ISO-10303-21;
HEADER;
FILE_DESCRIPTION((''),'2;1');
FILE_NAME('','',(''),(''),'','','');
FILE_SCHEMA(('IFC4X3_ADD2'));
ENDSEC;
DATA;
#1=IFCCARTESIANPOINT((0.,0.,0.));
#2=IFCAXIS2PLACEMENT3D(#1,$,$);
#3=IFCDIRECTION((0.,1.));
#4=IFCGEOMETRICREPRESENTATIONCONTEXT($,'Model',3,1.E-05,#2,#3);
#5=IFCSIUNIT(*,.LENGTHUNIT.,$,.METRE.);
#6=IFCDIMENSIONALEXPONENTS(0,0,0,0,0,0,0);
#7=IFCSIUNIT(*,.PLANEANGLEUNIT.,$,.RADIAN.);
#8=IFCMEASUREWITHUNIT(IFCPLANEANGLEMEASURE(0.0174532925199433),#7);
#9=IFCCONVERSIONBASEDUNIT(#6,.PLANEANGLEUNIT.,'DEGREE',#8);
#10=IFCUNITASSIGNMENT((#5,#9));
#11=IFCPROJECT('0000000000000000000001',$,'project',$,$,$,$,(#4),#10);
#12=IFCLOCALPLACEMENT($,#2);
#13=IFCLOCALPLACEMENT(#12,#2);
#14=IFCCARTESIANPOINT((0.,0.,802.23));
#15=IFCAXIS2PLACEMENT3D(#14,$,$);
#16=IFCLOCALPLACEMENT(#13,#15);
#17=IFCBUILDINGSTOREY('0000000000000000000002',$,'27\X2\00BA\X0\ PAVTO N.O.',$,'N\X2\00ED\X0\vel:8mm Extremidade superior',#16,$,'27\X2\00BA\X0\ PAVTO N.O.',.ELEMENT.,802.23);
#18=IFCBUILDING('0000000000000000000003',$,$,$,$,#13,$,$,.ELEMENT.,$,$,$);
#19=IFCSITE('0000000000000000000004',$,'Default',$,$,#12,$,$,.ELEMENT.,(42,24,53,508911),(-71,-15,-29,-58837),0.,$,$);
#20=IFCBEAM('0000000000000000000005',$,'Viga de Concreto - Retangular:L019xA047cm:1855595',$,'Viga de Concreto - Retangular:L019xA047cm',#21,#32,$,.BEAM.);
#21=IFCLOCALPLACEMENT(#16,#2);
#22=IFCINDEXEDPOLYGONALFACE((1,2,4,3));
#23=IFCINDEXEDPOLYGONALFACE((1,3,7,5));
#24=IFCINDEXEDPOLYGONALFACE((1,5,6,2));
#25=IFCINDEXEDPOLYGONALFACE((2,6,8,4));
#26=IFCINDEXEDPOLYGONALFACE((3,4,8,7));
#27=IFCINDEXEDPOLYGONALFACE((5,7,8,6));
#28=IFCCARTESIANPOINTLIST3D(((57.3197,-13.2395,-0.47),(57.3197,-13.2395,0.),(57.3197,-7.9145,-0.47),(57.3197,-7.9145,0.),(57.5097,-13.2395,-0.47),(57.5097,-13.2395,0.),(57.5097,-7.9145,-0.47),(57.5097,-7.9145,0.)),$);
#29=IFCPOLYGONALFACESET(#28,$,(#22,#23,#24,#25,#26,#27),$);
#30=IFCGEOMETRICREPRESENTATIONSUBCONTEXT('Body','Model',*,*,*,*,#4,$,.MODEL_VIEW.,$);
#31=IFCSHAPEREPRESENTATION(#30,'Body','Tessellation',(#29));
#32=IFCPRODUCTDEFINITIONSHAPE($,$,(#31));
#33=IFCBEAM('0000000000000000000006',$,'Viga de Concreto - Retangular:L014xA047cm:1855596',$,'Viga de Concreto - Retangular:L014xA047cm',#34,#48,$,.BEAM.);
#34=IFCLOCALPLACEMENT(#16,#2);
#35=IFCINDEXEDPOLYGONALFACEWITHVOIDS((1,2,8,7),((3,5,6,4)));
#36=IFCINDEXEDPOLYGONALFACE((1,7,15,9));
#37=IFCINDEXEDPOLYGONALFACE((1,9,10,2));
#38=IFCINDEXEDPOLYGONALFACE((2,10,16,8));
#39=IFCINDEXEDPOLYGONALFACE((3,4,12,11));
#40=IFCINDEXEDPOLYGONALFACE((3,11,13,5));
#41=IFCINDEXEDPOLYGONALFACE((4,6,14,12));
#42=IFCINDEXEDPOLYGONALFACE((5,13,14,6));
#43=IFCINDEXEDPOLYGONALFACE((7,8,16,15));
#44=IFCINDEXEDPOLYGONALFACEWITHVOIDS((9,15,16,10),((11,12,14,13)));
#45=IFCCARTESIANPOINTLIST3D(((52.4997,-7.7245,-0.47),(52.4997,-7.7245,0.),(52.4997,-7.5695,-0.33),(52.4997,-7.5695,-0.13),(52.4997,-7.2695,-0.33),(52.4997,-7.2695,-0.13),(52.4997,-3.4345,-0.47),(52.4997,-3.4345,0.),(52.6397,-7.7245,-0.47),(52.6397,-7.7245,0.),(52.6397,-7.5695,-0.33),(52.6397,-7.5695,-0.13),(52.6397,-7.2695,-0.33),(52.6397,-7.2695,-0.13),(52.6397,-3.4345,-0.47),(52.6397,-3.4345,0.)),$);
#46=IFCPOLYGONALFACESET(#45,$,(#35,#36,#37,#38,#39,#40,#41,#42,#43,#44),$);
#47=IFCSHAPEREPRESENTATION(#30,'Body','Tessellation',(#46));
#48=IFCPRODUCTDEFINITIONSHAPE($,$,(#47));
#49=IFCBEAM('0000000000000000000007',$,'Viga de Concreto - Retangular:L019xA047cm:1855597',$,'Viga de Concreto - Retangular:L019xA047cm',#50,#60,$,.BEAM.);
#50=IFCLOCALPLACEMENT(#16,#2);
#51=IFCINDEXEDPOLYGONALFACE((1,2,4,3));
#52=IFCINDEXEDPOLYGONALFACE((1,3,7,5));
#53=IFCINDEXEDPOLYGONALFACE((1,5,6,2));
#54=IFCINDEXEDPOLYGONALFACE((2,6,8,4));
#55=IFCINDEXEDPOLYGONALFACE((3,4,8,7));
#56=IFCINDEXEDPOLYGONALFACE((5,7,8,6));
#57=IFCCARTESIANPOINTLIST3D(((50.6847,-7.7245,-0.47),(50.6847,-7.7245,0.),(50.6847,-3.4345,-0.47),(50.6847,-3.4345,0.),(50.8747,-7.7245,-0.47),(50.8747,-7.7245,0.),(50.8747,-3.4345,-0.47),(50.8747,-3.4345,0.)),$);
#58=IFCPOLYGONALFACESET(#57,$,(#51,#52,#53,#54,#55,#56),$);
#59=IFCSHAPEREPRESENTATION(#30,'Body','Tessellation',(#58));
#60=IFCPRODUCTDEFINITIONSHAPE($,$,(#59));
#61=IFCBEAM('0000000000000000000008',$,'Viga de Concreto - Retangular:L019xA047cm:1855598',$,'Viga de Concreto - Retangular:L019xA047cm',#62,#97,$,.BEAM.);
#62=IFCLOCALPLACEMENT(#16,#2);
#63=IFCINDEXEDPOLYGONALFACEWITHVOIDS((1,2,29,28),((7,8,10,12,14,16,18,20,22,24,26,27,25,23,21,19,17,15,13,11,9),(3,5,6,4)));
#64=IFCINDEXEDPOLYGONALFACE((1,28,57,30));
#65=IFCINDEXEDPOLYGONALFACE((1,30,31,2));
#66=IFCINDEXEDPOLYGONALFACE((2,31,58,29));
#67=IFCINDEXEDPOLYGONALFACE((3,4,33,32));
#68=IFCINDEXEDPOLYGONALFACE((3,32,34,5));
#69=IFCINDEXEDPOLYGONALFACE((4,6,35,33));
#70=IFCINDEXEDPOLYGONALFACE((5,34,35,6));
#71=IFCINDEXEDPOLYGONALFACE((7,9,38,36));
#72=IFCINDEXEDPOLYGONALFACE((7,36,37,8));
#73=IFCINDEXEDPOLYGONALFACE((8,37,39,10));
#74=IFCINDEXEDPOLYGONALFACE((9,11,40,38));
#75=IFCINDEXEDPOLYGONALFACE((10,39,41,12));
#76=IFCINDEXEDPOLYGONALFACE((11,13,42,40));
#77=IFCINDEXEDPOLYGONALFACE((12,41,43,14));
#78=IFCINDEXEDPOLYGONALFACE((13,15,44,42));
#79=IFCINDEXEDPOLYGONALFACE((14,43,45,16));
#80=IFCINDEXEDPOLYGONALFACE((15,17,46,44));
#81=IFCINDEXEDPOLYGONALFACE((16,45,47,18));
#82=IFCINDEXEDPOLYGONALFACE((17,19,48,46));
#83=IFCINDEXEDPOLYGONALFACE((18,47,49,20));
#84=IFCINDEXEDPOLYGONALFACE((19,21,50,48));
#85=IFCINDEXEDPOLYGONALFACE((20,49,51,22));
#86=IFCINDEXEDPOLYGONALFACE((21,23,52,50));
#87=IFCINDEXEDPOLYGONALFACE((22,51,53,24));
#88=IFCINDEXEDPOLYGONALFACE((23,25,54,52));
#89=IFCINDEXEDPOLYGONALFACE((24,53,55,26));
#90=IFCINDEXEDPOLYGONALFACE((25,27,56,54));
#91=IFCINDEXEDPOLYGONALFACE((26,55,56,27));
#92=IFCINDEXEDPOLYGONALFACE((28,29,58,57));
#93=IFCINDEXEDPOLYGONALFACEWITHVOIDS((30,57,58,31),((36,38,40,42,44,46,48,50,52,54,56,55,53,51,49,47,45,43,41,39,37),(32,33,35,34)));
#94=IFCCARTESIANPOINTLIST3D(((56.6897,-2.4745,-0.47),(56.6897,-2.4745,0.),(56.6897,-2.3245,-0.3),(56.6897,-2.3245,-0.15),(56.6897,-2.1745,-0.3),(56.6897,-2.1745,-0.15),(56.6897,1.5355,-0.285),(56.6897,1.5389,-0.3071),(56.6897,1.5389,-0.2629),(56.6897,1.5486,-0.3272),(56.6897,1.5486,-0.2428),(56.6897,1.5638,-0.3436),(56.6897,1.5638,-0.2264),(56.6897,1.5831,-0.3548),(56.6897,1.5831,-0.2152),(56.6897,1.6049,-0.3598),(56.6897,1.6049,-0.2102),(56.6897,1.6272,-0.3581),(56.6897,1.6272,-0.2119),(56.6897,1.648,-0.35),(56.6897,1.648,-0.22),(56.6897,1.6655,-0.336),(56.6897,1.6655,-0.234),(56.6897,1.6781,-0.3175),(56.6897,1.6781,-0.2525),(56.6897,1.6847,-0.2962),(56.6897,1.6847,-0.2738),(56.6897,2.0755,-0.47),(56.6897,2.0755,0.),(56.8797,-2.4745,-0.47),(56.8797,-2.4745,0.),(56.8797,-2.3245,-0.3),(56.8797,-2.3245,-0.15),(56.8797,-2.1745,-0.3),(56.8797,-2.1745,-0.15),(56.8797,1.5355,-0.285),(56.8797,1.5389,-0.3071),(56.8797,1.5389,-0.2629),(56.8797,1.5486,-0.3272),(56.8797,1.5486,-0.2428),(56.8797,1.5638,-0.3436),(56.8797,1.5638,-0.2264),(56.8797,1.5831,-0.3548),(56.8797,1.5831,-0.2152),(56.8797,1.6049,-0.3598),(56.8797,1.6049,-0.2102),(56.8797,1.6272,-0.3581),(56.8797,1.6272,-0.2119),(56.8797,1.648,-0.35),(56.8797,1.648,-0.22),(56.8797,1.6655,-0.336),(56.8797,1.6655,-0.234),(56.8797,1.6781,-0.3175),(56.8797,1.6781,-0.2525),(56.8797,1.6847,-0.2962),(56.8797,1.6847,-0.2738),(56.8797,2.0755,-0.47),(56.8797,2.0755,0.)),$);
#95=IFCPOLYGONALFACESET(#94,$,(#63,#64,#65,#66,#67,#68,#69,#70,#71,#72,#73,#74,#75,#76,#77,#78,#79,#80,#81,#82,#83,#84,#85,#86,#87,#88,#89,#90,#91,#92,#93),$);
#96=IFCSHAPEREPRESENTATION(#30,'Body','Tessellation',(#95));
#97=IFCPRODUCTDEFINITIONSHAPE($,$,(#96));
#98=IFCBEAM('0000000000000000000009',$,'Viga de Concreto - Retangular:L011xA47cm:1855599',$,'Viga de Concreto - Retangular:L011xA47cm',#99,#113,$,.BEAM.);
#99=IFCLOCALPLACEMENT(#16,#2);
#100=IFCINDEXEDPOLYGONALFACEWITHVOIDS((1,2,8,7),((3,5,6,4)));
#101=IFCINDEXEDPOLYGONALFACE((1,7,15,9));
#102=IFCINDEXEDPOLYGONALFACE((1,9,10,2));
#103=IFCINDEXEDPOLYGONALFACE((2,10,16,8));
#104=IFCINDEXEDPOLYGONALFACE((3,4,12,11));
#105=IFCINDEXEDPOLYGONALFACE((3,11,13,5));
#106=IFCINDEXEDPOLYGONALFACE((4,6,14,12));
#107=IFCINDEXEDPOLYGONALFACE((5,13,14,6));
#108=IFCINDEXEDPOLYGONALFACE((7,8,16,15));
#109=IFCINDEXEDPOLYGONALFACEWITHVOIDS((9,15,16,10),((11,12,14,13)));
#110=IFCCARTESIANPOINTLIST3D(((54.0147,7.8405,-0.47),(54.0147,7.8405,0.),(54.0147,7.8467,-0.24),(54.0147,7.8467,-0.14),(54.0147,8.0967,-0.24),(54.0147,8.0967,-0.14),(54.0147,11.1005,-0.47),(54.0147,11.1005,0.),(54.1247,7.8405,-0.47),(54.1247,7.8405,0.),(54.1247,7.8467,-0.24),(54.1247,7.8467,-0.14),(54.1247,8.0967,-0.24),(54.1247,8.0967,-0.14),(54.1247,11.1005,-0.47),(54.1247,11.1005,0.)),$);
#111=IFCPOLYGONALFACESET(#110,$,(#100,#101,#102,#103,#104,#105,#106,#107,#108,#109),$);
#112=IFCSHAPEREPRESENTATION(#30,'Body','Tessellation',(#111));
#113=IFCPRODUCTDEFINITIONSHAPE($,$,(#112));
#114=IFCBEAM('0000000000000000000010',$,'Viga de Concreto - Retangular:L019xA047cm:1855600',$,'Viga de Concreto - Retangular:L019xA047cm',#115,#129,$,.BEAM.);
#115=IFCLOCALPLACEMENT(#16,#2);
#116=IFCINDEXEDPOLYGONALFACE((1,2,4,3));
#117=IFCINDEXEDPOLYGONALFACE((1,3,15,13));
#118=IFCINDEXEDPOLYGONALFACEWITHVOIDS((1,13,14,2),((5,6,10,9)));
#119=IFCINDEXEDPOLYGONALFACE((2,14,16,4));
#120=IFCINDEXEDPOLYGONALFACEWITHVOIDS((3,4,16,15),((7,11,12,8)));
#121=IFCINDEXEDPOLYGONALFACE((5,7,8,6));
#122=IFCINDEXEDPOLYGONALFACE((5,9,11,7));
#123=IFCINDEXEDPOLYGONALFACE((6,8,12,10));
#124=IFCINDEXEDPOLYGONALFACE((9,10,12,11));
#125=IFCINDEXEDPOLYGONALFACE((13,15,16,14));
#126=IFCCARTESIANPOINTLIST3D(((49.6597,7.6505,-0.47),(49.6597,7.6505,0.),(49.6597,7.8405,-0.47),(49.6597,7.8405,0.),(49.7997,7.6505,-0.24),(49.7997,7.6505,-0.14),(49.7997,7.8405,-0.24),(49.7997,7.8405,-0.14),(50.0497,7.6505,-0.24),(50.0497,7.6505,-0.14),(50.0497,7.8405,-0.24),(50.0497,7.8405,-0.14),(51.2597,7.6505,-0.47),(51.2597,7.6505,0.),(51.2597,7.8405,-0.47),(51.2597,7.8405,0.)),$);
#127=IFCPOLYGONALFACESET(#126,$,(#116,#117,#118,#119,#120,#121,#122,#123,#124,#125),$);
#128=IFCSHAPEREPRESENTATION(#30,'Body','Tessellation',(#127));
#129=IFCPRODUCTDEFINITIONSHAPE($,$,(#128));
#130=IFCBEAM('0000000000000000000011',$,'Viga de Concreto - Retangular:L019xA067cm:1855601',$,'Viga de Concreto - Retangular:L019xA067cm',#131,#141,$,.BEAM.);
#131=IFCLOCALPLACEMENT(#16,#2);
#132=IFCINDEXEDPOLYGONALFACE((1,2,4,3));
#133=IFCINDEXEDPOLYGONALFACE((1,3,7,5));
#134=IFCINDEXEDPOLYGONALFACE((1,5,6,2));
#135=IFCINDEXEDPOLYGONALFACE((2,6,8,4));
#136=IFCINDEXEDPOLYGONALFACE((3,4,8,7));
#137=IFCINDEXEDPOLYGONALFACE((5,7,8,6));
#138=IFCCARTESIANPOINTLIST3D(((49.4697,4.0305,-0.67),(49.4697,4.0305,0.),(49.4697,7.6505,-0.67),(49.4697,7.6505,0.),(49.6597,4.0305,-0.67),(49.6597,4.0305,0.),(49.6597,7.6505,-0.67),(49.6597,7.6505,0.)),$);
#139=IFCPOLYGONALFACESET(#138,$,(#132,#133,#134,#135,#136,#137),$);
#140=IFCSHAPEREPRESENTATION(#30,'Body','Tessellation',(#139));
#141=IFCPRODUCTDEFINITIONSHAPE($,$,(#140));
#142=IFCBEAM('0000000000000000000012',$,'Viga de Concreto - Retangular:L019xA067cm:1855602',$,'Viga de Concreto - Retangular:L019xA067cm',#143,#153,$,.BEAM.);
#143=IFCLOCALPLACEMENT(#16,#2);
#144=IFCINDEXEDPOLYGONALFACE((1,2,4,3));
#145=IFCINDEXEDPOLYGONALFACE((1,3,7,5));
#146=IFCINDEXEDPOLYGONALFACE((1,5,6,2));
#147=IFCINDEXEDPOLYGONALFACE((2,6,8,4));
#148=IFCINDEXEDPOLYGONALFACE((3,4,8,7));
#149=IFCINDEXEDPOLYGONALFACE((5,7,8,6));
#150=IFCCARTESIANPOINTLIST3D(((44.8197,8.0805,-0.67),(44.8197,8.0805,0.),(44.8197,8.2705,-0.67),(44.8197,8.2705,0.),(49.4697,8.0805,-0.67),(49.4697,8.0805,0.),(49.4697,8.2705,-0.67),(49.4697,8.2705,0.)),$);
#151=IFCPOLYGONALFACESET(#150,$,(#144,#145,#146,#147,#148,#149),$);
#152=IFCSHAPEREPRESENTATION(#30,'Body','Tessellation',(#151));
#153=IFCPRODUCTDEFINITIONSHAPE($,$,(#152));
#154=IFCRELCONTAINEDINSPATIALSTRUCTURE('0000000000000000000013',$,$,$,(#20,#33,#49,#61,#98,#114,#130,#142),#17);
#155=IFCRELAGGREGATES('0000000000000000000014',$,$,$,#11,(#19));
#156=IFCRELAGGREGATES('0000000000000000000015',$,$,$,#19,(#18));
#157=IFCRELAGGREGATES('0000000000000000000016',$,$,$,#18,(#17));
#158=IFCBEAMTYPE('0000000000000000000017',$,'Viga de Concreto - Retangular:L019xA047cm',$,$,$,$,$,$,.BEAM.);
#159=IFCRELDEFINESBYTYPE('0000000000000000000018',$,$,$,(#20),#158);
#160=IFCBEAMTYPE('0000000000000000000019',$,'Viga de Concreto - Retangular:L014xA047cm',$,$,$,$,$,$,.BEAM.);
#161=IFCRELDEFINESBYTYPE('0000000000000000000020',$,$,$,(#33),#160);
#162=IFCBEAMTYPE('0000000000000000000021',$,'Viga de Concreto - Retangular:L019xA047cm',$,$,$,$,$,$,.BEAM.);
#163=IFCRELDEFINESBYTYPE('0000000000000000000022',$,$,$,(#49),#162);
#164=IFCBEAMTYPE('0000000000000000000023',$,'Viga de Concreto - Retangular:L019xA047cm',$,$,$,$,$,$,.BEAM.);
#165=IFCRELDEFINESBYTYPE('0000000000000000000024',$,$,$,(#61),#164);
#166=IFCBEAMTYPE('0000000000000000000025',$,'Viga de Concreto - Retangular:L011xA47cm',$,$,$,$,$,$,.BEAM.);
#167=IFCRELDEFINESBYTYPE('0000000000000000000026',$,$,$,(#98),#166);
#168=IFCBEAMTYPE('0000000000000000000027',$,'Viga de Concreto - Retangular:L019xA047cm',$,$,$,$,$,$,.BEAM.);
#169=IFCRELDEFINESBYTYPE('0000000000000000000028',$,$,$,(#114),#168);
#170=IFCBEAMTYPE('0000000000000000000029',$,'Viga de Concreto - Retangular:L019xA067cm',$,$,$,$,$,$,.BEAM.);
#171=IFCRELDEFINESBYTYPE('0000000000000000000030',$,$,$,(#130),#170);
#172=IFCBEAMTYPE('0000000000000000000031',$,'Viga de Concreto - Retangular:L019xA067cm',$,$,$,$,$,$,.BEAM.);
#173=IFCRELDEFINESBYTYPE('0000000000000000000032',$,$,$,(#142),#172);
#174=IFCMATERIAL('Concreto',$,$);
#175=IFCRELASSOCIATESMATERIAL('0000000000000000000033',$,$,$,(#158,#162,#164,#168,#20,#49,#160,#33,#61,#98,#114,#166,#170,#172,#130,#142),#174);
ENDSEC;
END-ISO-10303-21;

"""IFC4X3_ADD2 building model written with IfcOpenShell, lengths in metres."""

from ifc_helpers import new_model, entity, si_unit, converted_unit, direction, frame, frame_2d, origin, origin_2d_with_axis, place, context, subcontext, project, spatial, polyline, segment, composite_curve, rectangle, circle, outline, extrude, boolean, source, transform, mapped, material, material_profile, profile_set, profile_usage, type_object, type_shapes, element, save


model = new_model("IFC4X3_ADD2")

# Units and contexts
model_context = context("Model", 3, precision=1e-05, world=origin(), true_north=direction((0.0, 1.0)))
body_context = subcontext(model_context, "Body", "Model", "MODEL_VIEW")
ifc_project = project(units=[si_unit("LENGTHUNIT", "METRE"), converted_unit("PLANEANGLEUNIT", "DEGREE", entity("IfcPlaneAngleMeasure", 0.0174532925199433), si_unit("PLANEANGLEUNIT", "RADIAN"), dimensions=[0, 0, 0, 0, 0, 0, 0])], contexts=[model_context])

# Site, building, storey
site_placement = place(None, origin())
site = spatial("IfcSite", under=ifc_project, at=site_placement, Name="Default", CompositionType="ELEMENT", RefLatitude=(42, 24, 53, 508911), RefLongitude=(-71, -15, -29, -58837), RefElevation=0.0)
building_placement = place(site_placement, origin())
building = spatial("IfcBuilding", under=site, at=building_placement, CompositionType="ELEMENT")
storey_placement = place(building_placement, frame((0.0, 0.0, 802.23)))
storey = spatial("IfcBuildingStorey", under=building, at=storey_placement, Name="27º PAVTO N.O.", ObjectType="Nível:8mm Extremidade superior", LongName="27º PAVTO N.O.", CompositionType="ELEMENT", Elevation=802.23)

# Beams
ifc_material = material(Name="Concreto")
ifc_material_profile_1 = material_profile(ifc_material, rectangle(XDim=0.47, YDim=0.14, at=frame_2d((0.0, 0.0), x_axis=(0.0, 1.0))), Name="L014xA047cm")
ifc_profile_set_1 = profile_set([ifc_material_profile_1], Name="L014xA047cm")
ifc_material_profile_2 = material_profile(ifc_material, rectangle(XDim=0.47, YDim=0.19, at=frame_2d((0.0, 0.0), x_axis=(0.0, 1.0))), Name="L019xA047cm")
ifc_profile_set_2 = profile_set([ifc_material_profile_2], Name="L019xA047cm")
ifc_profile_usage_1 = profile_usage(ifc_profile_set_2, cardinal=8)
ifc_material_profile_3 = material_profile(ifc_material, outline(composite_curve([segment(polyline([(-0.055, 0.235, 0.0), (0.055, 0.235, 0.0)]), True, "CONTINUOUS"), segment(polyline([(0.055, 0.235, 0.0), (0.055, -0.235, 0.0)]), True, "CONTINUOUS"), segment(polyline([(0.055, -0.235, 0.0), (-0.055, -0.235, 0.0)]), True, "CONTINUOUS"), segment(polyline([(-0.055, -0.235, 0.0), (-0.055, 0.235, 0.0)]), True, "CONTINUOUS")], self_intersect=False), kind="CURVE"), Name="L011xA47cm")
ifc_material_profile_4 = material_profile(ifc_material, outline(composite_curve([segment(polyline([(1.6775, -0.055, -0.235), (1.6775, -0.055, 0.235)]), True, "CONTINUOUS"), segment(polyline([(1.6775, -0.055, 0.235), (-1.6775, -0.055, 0.235)]), True, "CONTINUOUS"), segment(polyline([(-1.6775, -0.055, 0.235), (-1.6775, -0.055, -0.235)]), True, "CONTINUOUS"), segment(polyline([(-1.6775, -0.055, -0.235), (1.6775, -0.055, -0.235)]), True, "CONTINUOUS")], self_intersect=False), kind="CURVE"), Name="L011xA47cm")
ifc_profile_set_3 = profile_set([ifc_material_profile_3, ifc_material_profile_4], Name="L011xA47cm")
beam_type_1 = type_object("IfcBeamType", Name="Viga de Concreto - Retangular:L019xA047cm", PredefinedType="BEAM", material=ifc_profile_set_2)
shared_shape_1 = source(origin(), body_context, "Body", "SweptSolid", [
    extrude(rectangle(XDim=0.47, YDim=0.19, at=frame_2d((0.0, 0.0), x_axis=(0.0, 1.0))), frame((57.4147, -13.2395, 801.995), z_axis=(0.0, 1.0, 0.0), x_axis=(-1.0, 0.0, 0.0)), (0.0, 0.0, 1.0), 5.325),
])
type_shapes(beam_type_1, [shared_shape_1])
beam_1_placement = place(storey_placement, frame((0.0, 0.0, -802.23)))
element("IfcBeam", 1, at=beam_1_placement, inside=storey, type_object=beam_type_1, material=ifc_profile_usage_1, Name="Viga de Concreto - Retangular:L019xA047cm:1855595", ObjectType="Viga de Concreto - Retangular:L019xA047cm", PredefinedType="BEAM", context=body_context, shape_type="MappedRepresentation", body=[
    mapped(shared_shape_1, transform((0.0, 0.0, 0.0), scale=1.0)),
])
beam_type_2 = type_object("IfcBeamType", Name="Viga de Concreto - Retangular:L014xA047cm", PredefinedType="BEAM", material=ifc_profile_set_1)
shared_shape_2 = source(origin(), body_context, "Body", "CSG", [
    boolean("DIFFERENCE", extrude(rectangle(XDim=0.47, YDim=0.14, at=frame_2d((0.0, 0.0), x_axis=(0.0, 1.0))), frame((52.5697, -7.7245, 801.995), z_axis=(0.0, 1.0, 0.0), x_axis=(-1.0, 0.0, 0.0)), (0.0, 0.0, 1.0), 4.29), extrude(rectangle(XDim=0.2, YDim=0.3, at=frame_2d((0.0, 0.0), x_axis=(0.0, 1.0))), frame((52.6397, -7.4195, 802.0), z_axis=(-1.0, 0.0, 0.0), x_axis=(0.0, 1.0, 0.0)), (0.0, 0.0, 1.0), 0.14)),
])
type_shapes(beam_type_2, [shared_shape_2])
beam_2_placement = place(storey_placement, frame((0.0, 0.0, -802.23)))
element("IfcBeam", 2, at=beam_2_placement, inside=storey, type_object=beam_type_2, material=ifc_material, Name="Viga de Concreto - Retangular:L014xA047cm:1855596", ObjectType="Viga de Concreto - Retangular:L014xA047cm", PredefinedType="BEAM", context=body_context, shape_type="MappedRepresentation", body=[
    mapped(shared_shape_2, transform((0.0, 0.0, 0.0), scale=1.0)),
])
beam_type_3 = type_object("IfcBeamType", Name="Viga de Concreto - Retangular:L019xA047cm", PredefinedType="BEAM", material=ifc_profile_set_2)
shared_shape_3 = source(origin(), body_context, "Body", "SweptSolid", [
    extrude(rectangle(XDim=0.47, YDim=0.19, at=frame_2d((0.0, 0.0), x_axis=(0.0, 1.0))), frame((50.7797, -7.7245, 801.995), z_axis=(0.0, 1.0, 0.0), x_axis=(-1.0, 0.0, 0.0)), (0.0, 0.0, 1.0), 4.29),
])
type_shapes(beam_type_3, [shared_shape_3])
beam_3_placement = place(storey_placement, frame((0.0, 0.0, -802.23)))
element("IfcBeam", 3, at=beam_3_placement, inside=storey, type_object=beam_type_3, material=ifc_profile_usage_1, Name="Viga de Concreto - Retangular:L019xA047cm:1855597", ObjectType="Viga de Concreto - Retangular:L019xA047cm", PredefinedType="BEAM", context=body_context, shape_type="MappedRepresentation", body=[
    mapped(shared_shape_3, transform((0.0, 0.0, 0.0), scale=1.0)),
])
beam_type_4 = type_object("IfcBeamType", Name="Viga de Concreto - Retangular:L019xA047cm", PredefinedType="BEAM", material=ifc_profile_set_2)
shared_shape_4 = source(origin(), body_context, "Body", "CSG", [
    boolean("DIFFERENCE", boolean("DIFFERENCE", extrude(rectangle(XDim=0.47, YDim=0.19, at=frame_2d((0.0, 0.0), x_axis=(0.0, 1.0))), frame((56.7847, 2.0755, 801.995), z_axis=(0.0, -1.0, 0.0), x_axis=(-1.0, 0.0, 0.0)), (0.0, 0.0, 1.0), 4.55), extrude(circle(Radius=0.075, at=origin_2d_with_axis()), frame((56.6897, 1.6105, 801.945), z_axis=(1.0, 0.0, 0.0), x_axis=(0.0, -1.0, 0.0)), (0.0, 0.0, 1.0), 0.19)), extrude(rectangle(XDim=0.15, YDim=0.15, at=frame_2d((0.0, 0.0), x_axis=(0.0, 1.0))), frame((56.8797, -2.2495, 802.005), z_axis=(-1.0, 0.0, 0.0), x_axis=(0.0, 1.0, 0.0)), (0.0, 0.0, 1.0), 0.19)),
])
type_shapes(beam_type_4, [shared_shape_4])
beam_4_placement = place(storey_placement, frame((0.0, 0.0, -802.23)))
element("IfcBeam", 4, at=beam_4_placement, inside=storey, type_object=beam_type_4, material=ifc_material, Name="Viga de Concreto - Retangular:L019xA047cm:1855598", ObjectType="Viga de Concreto - Retangular:L019xA047cm", PredefinedType="BEAM", context=body_context, shape_type="MappedRepresentation", body=[
    mapped(shared_shape_4, transform((0.0, 0.0, 0.0), scale=1.0)),
])
beam_type_5 = type_object("IfcBeamType", Name="Viga de Concreto - Retangular:L011xA47cm", PredefinedType="BEAM", material=ifc_profile_set_3)
shared_shape_5 = source(origin(), body_context, "Body", "CSG", [
    boolean("DIFFERENCE", extrude(rectangle(XDim=0.47, YDim=0.11, at=frame_2d((0.0, 0.0), x_axis=(0.0, 1.0))), frame((54.0697, 7.8405, 801.995), z_axis=(0.0, 1.0, 0.0), x_axis=(-1.0, 0.0, 0.0)), (0.0, 0.0, 1.0), 3.26), extrude(rectangle(XDim=0.1, YDim=0.25, at=frame_2d((0.0, 0.0), x_axis=(0.0, 1.0))), frame((54.1247, 7.9717, 802.04), z_axis=(-1.0, 0.0, 0.0), x_axis=(0.0, 1.0, 0.0)), (0.0, 0.0, 1.0), 0.11)),
])
type_shapes(beam_type_5, [shared_shape_5])
beam_5_placement = place(storey_placement, frame((0.0, 0.0, -802.23)))
element("IfcBeam", 5, at=beam_5_placement, inside=storey, type_object=beam_type_5, material=ifc_material, Name="Viga de Concreto - Retangular:L011xA47cm:1855599", ObjectType="Viga de Concreto - Retangular:L011xA47cm", PredefinedType="BEAM", context=body_context, shape_type="MappedRepresentation", body=[
    mapped(shared_shape_5, transform((0.0, 0.0, 0.0), scale=1.0)),
])
beam_type_6 = type_object("IfcBeamType", Name="Viga de Concreto - Retangular:L019xA047cm", PredefinedType="BEAM", material=ifc_profile_set_2)
shared_shape_6 = source(origin(), body_context, "Body", "CSG", [
    boolean("DIFFERENCE", extrude(rectangle(XDim=0.47, YDim=0.19, at=frame_2d((0.0, 0.0), x_axis=(0.0, 1.0))), frame((49.6597, 7.7455, 801.995), z_axis=(1.0, 0.0, 0.0), x_axis=(0.0, 1.0, 0.0)), (0.0, 0.0, 1.0), 1.6), extrude(rectangle(XDim=0.1, YDim=0.25, at=frame_2d((0.0, 0.0), x_axis=(0.0, 1.0))), frame((49.9247, 7.8405, 802.04), z_axis=(0.0, -1.0, 0.0), x_axis=(-1.0, 0.0, 0.0)), (0.0, 0.0, 1.0), 0.19)),
])
type_shapes(beam_type_6, [shared_shape_6])
beam_6_placement = place(storey_placement, frame((0.0, 0.0, -802.23)))
element("IfcBeam", 6, at=beam_6_placement, inside=storey, type_object=beam_type_6, material=ifc_material, Name="Viga de Concreto - Retangular:L019xA047cm:1855600", ObjectType="Viga de Concreto - Retangular:L019xA047cm", PredefinedType="BEAM", context=body_context, shape_type="MappedRepresentation", body=[
    mapped(shared_shape_6, transform((0.0, 0.0, 0.0), scale=1.0)),
])
ifc_material_profile_5 = material_profile(ifc_material, rectangle(XDim=0.67, YDim=0.19, at=frame_2d((0.0, 0.0), x_axis=(0.0, 1.0))), Name="L019xA067cm")
ifc_profile_set_4 = profile_set([ifc_material_profile_5], Name="L019xA067cm")
ifc_profile_usage_2 = profile_usage(ifc_profile_set_4, cardinal=8)
beam_type_7 = type_object("IfcBeamType", Name="Viga de Concreto - Retangular:L019xA067cm", PredefinedType="BEAM", material=ifc_profile_set_4)
shared_shape_7 = source(origin(), body_context, "Body", "SweptSolid", [
    extrude(rectangle(XDim=0.67, YDim=0.19, at=frame_2d((0.0, 0.0), x_axis=(0.0, 1.0))), frame((49.5647, 4.0305, 801.895), z_axis=(0.0, 1.0, 0.0), x_axis=(-1.0, 0.0, 0.0)), (0.0, 0.0, 1.0), 3.62),
])
type_shapes(beam_type_7, [shared_shape_7])
beam_7_placement = place(storey_placement, frame((0.0, 0.0, -802.23)))
element("IfcBeam", 7, at=beam_7_placement, inside=storey, type_object=beam_type_7, material=ifc_profile_usage_2, Name="Viga de Concreto - Retangular:L019xA067cm:1855601", ObjectType="Viga de Concreto - Retangular:L019xA067cm", PredefinedType="BEAM", context=body_context, shape_type="MappedRepresentation", body=[
    mapped(shared_shape_7, transform((0.0, 0.0, 0.0), scale=1.0)),
])
beam_type_8 = type_object("IfcBeamType", Name="Viga de Concreto - Retangular:L019xA067cm", PredefinedType="BEAM", material=ifc_profile_set_4)
shared_shape_8 = source(origin(), body_context, "Body", "SweptSolid", [
    extrude(rectangle(XDim=0.67, YDim=0.19, at=frame_2d((0.0, 0.0), x_axis=(1.0, 0.0))), frame((44.8197, 8.1755, 801.895), z_axis=(1.0, 0.0, 0.0), x_axis=(0.0, 0.0, -1.0)), (0.0, 0.0, 1.0), 4.65),
])
type_shapes(beam_type_8, [shared_shape_8])
beam_8_placement = place(storey_placement, frame((0.0, 0.0, -802.23)))
element("IfcBeam", 8, at=beam_8_placement, inside=storey, type_object=beam_type_8, material=ifc_profile_usage_2, Name="Viga de Concreto - Retangular:L019xA067cm:1855602", ObjectType="Viga de Concreto - Retangular:L019xA067cm", PredefinedType="BEAM", context=body_context, shape_type="MappedRepresentation", body=[
    mapped(shared_shape_8, transform((0.0, 0.0, 0.0), scale=1.0)),
])

save(model, "model.ifc")
